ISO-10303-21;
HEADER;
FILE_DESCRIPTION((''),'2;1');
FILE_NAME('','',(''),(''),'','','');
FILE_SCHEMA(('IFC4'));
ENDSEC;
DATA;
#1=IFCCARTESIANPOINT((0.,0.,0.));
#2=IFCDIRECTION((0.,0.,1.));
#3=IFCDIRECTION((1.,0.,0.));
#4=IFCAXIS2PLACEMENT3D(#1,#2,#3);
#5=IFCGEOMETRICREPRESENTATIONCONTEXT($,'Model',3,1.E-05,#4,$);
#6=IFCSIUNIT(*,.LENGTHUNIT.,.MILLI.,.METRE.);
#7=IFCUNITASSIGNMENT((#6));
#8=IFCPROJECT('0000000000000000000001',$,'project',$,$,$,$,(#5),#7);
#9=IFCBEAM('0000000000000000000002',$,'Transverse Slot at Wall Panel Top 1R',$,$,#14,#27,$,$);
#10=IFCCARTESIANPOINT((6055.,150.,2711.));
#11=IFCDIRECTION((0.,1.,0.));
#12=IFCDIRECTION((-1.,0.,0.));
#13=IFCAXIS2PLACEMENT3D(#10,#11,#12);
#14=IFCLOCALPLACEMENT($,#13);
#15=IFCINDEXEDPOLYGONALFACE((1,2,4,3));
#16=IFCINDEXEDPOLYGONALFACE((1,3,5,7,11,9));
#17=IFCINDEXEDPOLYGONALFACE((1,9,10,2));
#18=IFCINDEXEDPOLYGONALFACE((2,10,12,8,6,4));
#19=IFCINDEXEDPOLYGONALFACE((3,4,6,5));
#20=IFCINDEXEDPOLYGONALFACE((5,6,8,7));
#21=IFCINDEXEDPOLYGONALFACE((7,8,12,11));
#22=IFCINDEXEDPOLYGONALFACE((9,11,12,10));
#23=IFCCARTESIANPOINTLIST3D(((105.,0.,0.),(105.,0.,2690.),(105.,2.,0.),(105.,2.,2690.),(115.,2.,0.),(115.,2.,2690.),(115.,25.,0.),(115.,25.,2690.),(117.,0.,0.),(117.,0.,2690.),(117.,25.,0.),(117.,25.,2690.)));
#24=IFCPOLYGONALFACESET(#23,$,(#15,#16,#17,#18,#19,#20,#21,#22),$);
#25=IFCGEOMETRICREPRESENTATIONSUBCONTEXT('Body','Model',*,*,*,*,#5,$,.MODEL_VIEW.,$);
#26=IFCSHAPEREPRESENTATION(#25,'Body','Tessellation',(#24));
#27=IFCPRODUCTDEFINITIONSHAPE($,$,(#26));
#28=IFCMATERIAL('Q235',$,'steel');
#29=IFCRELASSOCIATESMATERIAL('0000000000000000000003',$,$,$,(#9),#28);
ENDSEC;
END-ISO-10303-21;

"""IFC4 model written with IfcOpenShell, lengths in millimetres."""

from ifc_helpers import new_model, si_unit, frame, origin_with_axes, place, context, subcontext, project, line, indexed_curve, outline, extrude, material, element, save


model = new_model("IFC4")

# Units and contexts
model_context = context("Model", 3, precision=1e-05, world=origin_with_axes())
body_context = subcontext(model_context, "Body", "Model", "MODEL_VIEW")
ifc_project = project(units=[si_unit("LENGTHUNIT", "METRE", prefix="MILLI")], contexts=[model_context])

# Beam
ifc_material_1 = material(Name="Q235", Category="steel")
beam_1_placement = place(None, frame((6055.0, 150.0, 2711.0), z_axis=(0.0, 1.0, 0.0), x_axis=(-1.0, 0.0, 0.0)))
element("IfcBeam", 1, at=beam_1_placement, material=ifc_material_1, Name="Transverse Slot at Wall Panel Top 1R", context=body_context, shape_type="SweptSolid", body=[
    extrude(outline(indexed_curve([(117.0, 0.0), (105.0, 0.0), (105.0, 2.0), (115.0, 2.0), (115.0, 25.0), (117.0, 25.0), (117.0, 0.0)], segments=[line(1, 2, 3, 4, 5, 6, 7, 1)])), origin_with_axes(), (0.0, 0.0, 1.0), 2690.0),
])

save(model, "model.ifc")
